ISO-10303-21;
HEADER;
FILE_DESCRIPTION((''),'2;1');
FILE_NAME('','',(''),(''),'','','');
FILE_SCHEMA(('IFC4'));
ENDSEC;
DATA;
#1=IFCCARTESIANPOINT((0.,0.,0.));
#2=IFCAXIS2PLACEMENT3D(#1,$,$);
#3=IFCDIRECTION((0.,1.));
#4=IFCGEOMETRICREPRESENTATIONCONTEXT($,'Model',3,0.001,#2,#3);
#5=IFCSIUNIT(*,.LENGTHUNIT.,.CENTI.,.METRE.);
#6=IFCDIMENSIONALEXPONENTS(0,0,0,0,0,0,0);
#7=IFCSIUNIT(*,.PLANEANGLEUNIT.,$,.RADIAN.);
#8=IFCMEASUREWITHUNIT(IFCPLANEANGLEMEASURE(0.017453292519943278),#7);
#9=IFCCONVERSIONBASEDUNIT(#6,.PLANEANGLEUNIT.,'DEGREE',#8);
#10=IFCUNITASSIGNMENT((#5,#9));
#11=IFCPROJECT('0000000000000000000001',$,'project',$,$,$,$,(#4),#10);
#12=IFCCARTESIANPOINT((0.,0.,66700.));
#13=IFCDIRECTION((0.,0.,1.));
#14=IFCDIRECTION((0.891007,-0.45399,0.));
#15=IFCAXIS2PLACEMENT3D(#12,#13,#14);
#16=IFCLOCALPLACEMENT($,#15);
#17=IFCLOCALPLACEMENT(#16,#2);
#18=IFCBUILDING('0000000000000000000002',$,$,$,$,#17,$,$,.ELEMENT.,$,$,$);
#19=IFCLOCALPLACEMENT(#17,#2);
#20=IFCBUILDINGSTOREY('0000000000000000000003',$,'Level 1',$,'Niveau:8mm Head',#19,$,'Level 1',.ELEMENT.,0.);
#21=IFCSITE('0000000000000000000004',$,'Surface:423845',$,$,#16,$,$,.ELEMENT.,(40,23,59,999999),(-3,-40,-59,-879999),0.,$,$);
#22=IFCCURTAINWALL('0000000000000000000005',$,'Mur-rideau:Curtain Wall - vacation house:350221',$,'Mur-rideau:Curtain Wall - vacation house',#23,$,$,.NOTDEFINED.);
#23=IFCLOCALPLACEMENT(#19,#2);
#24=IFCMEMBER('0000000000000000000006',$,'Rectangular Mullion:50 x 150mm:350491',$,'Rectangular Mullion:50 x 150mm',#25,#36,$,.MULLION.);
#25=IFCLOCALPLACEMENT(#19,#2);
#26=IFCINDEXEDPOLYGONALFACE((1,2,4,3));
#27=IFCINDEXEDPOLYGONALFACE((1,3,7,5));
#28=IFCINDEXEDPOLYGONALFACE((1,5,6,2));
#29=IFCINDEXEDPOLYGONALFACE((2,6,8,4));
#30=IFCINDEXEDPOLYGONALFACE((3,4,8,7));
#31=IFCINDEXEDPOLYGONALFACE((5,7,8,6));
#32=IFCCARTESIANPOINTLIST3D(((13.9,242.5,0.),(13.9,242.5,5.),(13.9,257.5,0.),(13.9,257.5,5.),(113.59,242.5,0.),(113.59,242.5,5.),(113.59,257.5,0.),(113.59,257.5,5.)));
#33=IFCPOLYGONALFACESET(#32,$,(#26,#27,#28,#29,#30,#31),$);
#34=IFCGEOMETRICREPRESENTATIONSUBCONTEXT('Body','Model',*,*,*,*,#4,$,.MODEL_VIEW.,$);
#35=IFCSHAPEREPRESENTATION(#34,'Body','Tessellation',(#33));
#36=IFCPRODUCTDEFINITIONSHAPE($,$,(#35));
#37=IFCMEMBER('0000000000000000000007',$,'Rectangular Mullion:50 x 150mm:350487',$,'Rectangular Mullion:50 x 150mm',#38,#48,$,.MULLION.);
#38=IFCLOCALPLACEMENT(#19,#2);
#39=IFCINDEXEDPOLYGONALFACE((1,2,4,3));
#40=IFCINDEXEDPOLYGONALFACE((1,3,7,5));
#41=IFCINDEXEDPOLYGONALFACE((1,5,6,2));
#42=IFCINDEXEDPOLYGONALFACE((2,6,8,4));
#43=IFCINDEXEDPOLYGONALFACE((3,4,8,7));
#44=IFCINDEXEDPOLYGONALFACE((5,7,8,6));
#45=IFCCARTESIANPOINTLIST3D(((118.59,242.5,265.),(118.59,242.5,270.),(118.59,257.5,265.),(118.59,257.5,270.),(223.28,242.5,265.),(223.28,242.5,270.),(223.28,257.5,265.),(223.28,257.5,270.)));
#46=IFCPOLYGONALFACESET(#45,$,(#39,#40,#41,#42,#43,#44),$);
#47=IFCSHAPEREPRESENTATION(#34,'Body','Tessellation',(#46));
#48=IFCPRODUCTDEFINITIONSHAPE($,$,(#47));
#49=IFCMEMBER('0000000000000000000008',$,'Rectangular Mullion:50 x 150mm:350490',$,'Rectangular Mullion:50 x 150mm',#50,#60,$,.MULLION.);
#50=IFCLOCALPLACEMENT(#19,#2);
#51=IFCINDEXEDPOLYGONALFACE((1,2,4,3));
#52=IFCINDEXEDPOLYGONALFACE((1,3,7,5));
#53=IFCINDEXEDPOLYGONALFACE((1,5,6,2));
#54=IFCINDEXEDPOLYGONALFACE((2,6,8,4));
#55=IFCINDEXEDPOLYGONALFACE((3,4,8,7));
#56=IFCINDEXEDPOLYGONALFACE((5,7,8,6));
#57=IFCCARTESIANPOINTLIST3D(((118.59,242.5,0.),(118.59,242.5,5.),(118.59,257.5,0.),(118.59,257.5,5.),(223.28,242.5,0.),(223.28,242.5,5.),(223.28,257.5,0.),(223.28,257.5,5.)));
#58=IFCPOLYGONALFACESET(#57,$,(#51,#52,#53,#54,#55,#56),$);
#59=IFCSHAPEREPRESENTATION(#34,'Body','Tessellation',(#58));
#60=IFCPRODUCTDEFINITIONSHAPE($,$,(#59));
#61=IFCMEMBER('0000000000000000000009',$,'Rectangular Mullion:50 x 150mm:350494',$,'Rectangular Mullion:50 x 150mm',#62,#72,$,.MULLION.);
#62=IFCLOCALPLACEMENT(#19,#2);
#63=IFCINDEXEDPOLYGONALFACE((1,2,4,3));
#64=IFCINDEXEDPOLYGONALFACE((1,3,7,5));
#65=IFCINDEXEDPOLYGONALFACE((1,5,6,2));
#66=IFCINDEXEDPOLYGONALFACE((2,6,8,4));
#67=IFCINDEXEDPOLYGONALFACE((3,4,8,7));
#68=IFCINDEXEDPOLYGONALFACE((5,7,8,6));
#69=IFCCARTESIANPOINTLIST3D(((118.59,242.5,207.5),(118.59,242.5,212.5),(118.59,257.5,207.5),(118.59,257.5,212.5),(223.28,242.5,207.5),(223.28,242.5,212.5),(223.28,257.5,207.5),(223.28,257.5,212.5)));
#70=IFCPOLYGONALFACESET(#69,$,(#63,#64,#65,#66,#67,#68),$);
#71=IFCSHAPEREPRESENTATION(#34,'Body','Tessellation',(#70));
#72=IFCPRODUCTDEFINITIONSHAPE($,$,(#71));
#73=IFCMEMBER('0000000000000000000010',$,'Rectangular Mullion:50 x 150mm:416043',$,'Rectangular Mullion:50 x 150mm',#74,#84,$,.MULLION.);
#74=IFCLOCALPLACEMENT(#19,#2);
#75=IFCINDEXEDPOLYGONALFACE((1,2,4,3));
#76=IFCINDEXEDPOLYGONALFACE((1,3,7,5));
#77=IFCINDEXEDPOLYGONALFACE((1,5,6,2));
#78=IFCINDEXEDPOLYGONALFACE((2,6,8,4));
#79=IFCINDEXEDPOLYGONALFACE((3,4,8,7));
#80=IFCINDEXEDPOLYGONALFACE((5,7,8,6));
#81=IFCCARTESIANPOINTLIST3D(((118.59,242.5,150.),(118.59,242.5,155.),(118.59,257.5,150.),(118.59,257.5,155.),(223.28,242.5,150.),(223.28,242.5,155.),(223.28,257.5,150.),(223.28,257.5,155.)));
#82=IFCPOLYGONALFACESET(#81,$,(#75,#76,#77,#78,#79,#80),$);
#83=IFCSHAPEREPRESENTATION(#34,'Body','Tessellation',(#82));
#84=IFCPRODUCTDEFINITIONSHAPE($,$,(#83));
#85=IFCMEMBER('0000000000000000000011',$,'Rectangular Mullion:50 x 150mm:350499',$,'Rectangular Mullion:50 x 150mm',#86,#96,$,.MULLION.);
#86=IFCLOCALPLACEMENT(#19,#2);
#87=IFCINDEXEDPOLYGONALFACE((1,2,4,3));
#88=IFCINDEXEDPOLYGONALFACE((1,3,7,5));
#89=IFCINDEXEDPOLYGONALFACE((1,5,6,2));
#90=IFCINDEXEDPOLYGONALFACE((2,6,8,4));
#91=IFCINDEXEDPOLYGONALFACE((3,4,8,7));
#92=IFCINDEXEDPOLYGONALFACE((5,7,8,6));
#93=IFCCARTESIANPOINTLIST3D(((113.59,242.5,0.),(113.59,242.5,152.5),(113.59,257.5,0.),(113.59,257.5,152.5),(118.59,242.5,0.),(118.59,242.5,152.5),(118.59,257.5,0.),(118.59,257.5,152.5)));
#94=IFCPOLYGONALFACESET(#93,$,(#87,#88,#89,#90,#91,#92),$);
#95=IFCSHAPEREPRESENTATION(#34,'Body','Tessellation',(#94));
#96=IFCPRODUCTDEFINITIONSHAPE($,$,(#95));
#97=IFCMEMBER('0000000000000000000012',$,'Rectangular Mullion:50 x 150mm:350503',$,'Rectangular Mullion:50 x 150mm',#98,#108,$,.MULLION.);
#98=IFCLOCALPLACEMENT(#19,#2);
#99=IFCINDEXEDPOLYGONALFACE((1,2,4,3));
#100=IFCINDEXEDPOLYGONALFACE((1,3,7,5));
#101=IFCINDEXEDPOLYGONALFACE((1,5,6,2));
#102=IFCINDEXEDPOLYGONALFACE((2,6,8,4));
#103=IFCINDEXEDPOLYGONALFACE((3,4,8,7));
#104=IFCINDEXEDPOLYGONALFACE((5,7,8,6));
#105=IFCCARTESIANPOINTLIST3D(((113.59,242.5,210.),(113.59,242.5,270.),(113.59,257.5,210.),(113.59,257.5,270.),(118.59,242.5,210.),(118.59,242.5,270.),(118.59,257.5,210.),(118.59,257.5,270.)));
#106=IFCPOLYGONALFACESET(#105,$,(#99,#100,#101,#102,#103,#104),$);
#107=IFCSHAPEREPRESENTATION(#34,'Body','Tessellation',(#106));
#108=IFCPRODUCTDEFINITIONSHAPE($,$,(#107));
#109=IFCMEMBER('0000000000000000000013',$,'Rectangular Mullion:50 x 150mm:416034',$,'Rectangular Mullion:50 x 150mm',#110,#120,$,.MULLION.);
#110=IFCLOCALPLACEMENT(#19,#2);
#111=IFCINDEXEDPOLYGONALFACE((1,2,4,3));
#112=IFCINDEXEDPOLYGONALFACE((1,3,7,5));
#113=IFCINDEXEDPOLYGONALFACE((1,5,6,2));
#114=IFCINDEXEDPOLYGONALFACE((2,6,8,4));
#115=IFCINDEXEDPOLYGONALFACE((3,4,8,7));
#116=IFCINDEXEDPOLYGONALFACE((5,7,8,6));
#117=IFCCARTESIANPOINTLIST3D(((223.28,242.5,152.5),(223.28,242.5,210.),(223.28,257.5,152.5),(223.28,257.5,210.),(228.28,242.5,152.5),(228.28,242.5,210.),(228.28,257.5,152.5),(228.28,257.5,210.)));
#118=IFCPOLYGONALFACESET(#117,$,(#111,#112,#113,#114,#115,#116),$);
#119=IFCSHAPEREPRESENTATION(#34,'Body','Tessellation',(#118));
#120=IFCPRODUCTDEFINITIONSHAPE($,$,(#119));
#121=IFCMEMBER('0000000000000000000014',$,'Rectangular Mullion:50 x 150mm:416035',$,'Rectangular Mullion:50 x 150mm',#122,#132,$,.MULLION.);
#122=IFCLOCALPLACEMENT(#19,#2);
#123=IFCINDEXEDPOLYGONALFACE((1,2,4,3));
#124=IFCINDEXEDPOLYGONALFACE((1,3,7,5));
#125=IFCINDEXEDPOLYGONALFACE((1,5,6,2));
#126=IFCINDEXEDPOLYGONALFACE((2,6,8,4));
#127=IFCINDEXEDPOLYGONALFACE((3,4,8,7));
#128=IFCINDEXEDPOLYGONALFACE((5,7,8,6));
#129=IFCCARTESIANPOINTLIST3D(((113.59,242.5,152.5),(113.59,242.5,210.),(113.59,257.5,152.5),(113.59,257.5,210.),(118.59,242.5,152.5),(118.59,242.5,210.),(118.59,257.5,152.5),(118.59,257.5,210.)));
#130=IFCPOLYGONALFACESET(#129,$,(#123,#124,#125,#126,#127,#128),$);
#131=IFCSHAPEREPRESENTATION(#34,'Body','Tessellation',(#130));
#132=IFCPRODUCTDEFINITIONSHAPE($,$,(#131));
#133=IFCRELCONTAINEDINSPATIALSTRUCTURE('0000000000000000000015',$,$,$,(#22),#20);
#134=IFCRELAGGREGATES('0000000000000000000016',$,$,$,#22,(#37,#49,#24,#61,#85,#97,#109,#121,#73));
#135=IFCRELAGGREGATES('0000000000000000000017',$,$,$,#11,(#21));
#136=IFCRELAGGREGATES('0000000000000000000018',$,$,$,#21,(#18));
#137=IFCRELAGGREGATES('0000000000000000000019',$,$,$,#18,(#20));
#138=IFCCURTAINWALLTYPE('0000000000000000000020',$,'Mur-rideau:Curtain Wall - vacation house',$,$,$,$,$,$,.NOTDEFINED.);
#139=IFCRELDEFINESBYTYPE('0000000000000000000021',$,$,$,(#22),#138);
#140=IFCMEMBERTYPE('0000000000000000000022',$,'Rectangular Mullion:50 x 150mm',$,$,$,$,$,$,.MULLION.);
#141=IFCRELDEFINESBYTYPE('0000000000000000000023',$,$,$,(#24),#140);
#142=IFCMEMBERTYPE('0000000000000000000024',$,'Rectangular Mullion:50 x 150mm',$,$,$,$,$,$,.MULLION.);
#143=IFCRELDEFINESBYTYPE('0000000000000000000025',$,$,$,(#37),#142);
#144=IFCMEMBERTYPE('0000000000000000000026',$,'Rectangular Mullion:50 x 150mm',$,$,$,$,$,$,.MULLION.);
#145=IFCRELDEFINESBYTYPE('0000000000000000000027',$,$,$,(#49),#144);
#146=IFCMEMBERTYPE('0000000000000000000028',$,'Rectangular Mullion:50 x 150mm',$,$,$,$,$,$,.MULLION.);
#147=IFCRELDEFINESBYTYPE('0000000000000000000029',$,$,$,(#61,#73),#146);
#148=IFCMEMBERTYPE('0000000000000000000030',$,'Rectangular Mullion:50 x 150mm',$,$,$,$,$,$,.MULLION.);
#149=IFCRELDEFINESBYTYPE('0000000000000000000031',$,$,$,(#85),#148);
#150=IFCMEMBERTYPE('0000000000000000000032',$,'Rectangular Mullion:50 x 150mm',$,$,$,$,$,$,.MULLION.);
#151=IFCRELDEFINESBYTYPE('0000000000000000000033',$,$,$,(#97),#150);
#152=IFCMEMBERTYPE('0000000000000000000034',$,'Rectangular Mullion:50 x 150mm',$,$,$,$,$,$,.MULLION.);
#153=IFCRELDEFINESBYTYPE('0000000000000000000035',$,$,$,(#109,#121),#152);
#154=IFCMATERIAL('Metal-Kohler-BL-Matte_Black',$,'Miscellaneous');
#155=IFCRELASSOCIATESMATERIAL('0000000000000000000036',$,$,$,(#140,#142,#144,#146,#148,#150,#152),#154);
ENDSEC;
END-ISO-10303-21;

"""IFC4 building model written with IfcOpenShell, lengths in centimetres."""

from ifc_helpers import new_model, entity, si_unit, converted_unit, direction, frame, origin, origin_2d_with_axis, place, context, subcontext, project, spatial, rectangle, extrude, source, transform, mapped, material, material_profile, profile_set, type_object, type_shapes, element, aggregate, save


model = new_model("IFC4")

# Units and contexts
model_context = context("Model", 3, precision=0.001, world=origin(), true_north=direction((0.0, 1.0)))
body_context = subcontext(model_context, "Body", "Model", "MODEL_VIEW")
ifc_project = project(units=[si_unit("LENGTHUNIT", "METRE", prefix="CENTI"), converted_unit("PLANEANGLEUNIT", "DEGREE", entity("IfcPlaneAngleMeasure", 0.017453292519943278), si_unit("PLANEANGLEUNIT", "RADIAN"), dimensions=[0, 0, 0, 0, 0, 0, 0])], contexts=[model_context])

# Site, building, storey
site_placement = place(None, frame((0.0, 0.0, 66700.0), z_axis=(0.0, 0.0, 1.0), x_axis=(0.891007, -0.45399, 0.0)))
site = spatial("IfcSite", under=ifc_project, at=site_placement, Name="Surface:423845", CompositionType="ELEMENT", RefLatitude=(40, 23, 59, 999999), RefLongitude=(-3, -40, -59, -879999), RefElevation=0.0)
building_placement = place(site_placement, origin())
building = spatial("IfcBuilding", under=site, at=building_placement, CompositionType="ELEMENT")
storey_placement = place(building_placement, origin())
storey = spatial("IfcBuildingStorey", under=building, at=storey_placement, Name="Level 1", ObjectType="Niveau:8mm Head", LongName="Level 1", CompositionType="ELEMENT", Elevation=0.0)

# Curtain wall, members
curtain_wall_type = type_object("IfcCurtainWallType", Name="Mur-rideau:Curtain Wall - vacation house", PredefinedType="NOTDEFINED")
curtain_wall_placement = place(storey_placement, origin())
curtain_wall = element("IfcCurtainWall", 1, at=curtain_wall_placement, inside=storey, type_object=curtain_wall_type, Name="Mur-rideau:Curtain Wall - vacation house:350221", ObjectType="Mur-rideau:Curtain Wall - vacation house", PredefinedType="NOTDEFINED")
ifc_material_1 = material(Name="Metal-Kohler-BL-Matte_Black", Category="Miscellaneous")
ifc_material_profile = material_profile(ifc_material_1, rectangle(XDim=5.0, YDim=15.0, at=origin_2d_with_axis()), Name="50 x 150mm")
ifc_profile_set = profile_set([ifc_material_profile], Name="50 x 150mm")
member_type_1 = type_object("IfcMemberType", Name="Rectangular Mullion:50 x 150mm", PredefinedType="MULLION", material=ifc_profile_set)
shared_shape_1 = source(origin(), body_context, "Body", "SweptSolid", [
    extrude(rectangle(XDim=5.0, YDim=15.0, at=origin_2d_with_axis()), frame((-2.5, 0.0, -99.69), z_axis=(0.0, 0.0, 1.0), x_axis=(-1.0, 0.0, 0.0)), (0.0, 0.0, 1.0), 99.69),
])
type_shapes(member_type_1, [shared_shape_1])
member_1_placement = place(curtain_wall_placement, frame((113.59, 250.0, 0.0), z_axis=(1.0, 0.0, 0.0), x_axis=(0.0, 0.0, -1.0)))
member_1 = element("IfcMember", 2, at=member_1_placement, type_object=member_type_1, Name="Rectangular Mullion:50 x 150mm:350491", ObjectType="Rectangular Mullion:50 x 150mm", PredefinedType="MULLION", context=body_context, shape_type="MappedRepresentation", body=[
    mapped(shared_shape_1, transform((0.0, 0.0, 0.0), scale=1.0)),
])
member_type_2 = type_object("IfcMemberType", Name="Rectangular Mullion:50 x 150mm", PredefinedType="MULLION", material=ifc_profile_set)
shared_shape_2 = source(origin(), body_context, "Body", "SweptSolid", [
    extrude(rectangle(XDim=5.0, YDim=15.0, at=origin_2d_with_axis()), frame((-2.5, 0.0, -104.69), z_axis=(0.0, 0.0, 1.0), x_axis=(-1.0, 0.0, 0.0)), (0.0, 0.0, 1.0), 104.69),
])
type_shapes(member_type_2, [shared_shape_2])
member_2_placement = place(curtain_wall_placement, frame((118.59, 250.0, 270.0), z_axis=(-1.0, 0.0, 0.0), x_axis=(0.0, 0.0, 1.0)))
member_2 = element("IfcMember", 3, at=member_2_placement, type_object=member_type_2, Name="Rectangular Mullion:50 x 150mm:350487", ObjectType="Rectangular Mullion:50 x 150mm", PredefinedType="MULLION", context=body_context, shape_type="MappedRepresentation", body=[
    mapped(shared_shape_2, transform((0.0, 0.0, 0.0), scale=1.0)),
])
member_type_3 = type_object("IfcMemberType", Name="Rectangular Mullion:50 x 150mm", PredefinedType="MULLION", material=ifc_profile_set)
shared_shape_3 = source(origin(), body_context, "Body", "SweptSolid", [
    extrude(rectangle(XDim=5.0, YDim=15.0, at=origin_2d_with_axis()), frame((-2.5, 0.0, -104.69), z_axis=(0.0, 0.0, 1.0), x_axis=(-1.0, 0.0, 0.0)), (0.0, 0.0, 1.0), 104.69),
])
type_shapes(member_type_3, [shared_shape_3])
member_3_placement = place(curtain_wall_placement, frame((223.28, 250.0, 0.0), z_axis=(1.0, 0.0, 0.0), x_axis=(0.0, 0.0, -1.0)))
member_3 = element("IfcMember", 4, at=member_3_placement, type_object=member_type_3, Name="Rectangular Mullion:50 x 150mm:350490", ObjectType="Rectangular Mullion:50 x 150mm", PredefinedType="MULLION", context=body_context, shape_type="MappedRepresentation", body=[
    mapped(shared_shape_3, transform((0.0, 0.0, 0.0), scale=1.0)),
])
member_type_4 = type_object("IfcMemberType", Name="Rectangular Mullion:50 x 150mm", PredefinedType="MULLION", material=ifc_profile_set)
shared_shape_4 = source(origin(), body_context, "Body", "SweptSolid", [
    extrude(rectangle(XDim=5.0, YDim=15.0, at=origin_2d_with_axis()), frame((0.0, 0.0, -104.69), z_axis=(0.0, 0.0, 1.0), x_axis=(-1.0, 0.0, 0.0)), (0.0, 0.0, 1.0), 104.69),
])
type_shapes(member_type_4, [shared_shape_4])
member_4_placement = place(curtain_wall_placement, frame((118.59, 250.0, 210.0), z_axis=(-1.0, 0.0, 0.0), x_axis=(0.0, 0.0, 1.0)))
member_4 = element("IfcMember", 5, at=member_4_placement, type_object=member_type_4, Name="Rectangular Mullion:50 x 150mm:350494", ObjectType="Rectangular Mullion:50 x 150mm", PredefinedType="MULLION", context=body_context, shape_type="MappedRepresentation", body=[
    mapped(shared_shape_4, transform((0.0, 0.0, 0.0), scale=1.0)),
])
member_5_placement = place(curtain_wall_placement, frame((118.59, 250.0, 152.5), z_axis=(-1.0, 0.0, 0.0), x_axis=(0.0, 0.0, 1.0)))
member_5 = element("IfcMember", 6, at=member_5_placement, type_object=member_type_4, Name="Rectangular Mullion:50 x 150mm:416043", ObjectType="Rectangular Mullion:50 x 150mm", PredefinedType="MULLION", context=body_context, shape_type="MappedRepresentation", body=[
    mapped(shared_shape_4, transform((0.0, 0.0, 0.0), scale=1.0)),
])
member_type_5 = type_object("IfcMemberType", Name="Rectangular Mullion:50 x 150mm", PredefinedType="MULLION", material=ifc_profile_set)
shared_shape_5 = source(origin(), body_context, "Body", "SweptSolid", [
    extrude(rectangle(XDim=5.0, YDim=15.0, at=origin_2d_with_axis()), frame((0.0, 0.0, -152.5), z_axis=(0.0, 0.0, 1.0), x_axis=(-1.0, 0.0, 0.0)), (0.0, 0.0, 1.0), 152.5),
])
type_shapes(member_type_5, [shared_shape_5])
member_6_placement = place(curtain_wall_placement, frame((116.09, 250.0, 0.0), z_axis=(0.0, 0.0, -1.0), x_axis=(-1.0, 0.0, 0.0)))
member_6 = element("IfcMember", 7, at=member_6_placement, type_object=member_type_5, Name="Rectangular Mullion:50 x 150mm:350499", ObjectType="Rectangular Mullion:50 x 150mm", PredefinedType="MULLION", context=body_context, shape_type="MappedRepresentation", body=[
    mapped(shared_shape_5, transform((0.0, 0.0, 0.0), scale=1.0)),
])
member_type_6 = type_object("IfcMemberType", Name="Rectangular Mullion:50 x 150mm", PredefinedType="MULLION", material=ifc_profile_set)
shared_shape_6 = source(origin(), body_context, "Body", "SweptSolid", [
    extrude(rectangle(XDim=5.0, YDim=15.0, at=origin_2d_with_axis()), frame((0.0, 0.0, -60.0), z_axis=(0.0, 0.0, 1.0), x_axis=(-1.0, 0.0, 0.0)), (0.0, 0.0, 1.0), 60.0),
])
type_shapes(member_type_6, [shared_shape_6])
member_7_placement = place(curtain_wall_placement, frame((116.09, 250.0, 210.0), z_axis=(0.0, 0.0, -1.0), x_axis=(-1.0, 0.0, 0.0)))
member_7 = element("IfcMember", 8, at=member_7_placement, type_object=member_type_6, Name="Rectangular Mullion:50 x 150mm:350503", ObjectType="Rectangular Mullion:50 x 150mm", PredefinedType="MULLION", context=body_context, shape_type="MappedRepresentation", body=[
    mapped(shared_shape_6, transform((0.0, 0.0, 0.0), scale=1.0)),
])
member_type_7 = type_object("IfcMemberType", Name="Rectangular Mullion:50 x 150mm", PredefinedType="MULLION", material=ifc_profile_set)
shared_shape_7 = source(origin(), body_context, "Body", "SweptSolid", [
    extrude(rectangle(XDim=5.0, YDim=15.0, at=origin_2d_with_axis()), frame((0.0, 0.0, -57.5), z_axis=(0.0, 0.0, 1.0), x_axis=(-1.0, 0.0, 0.0)), (0.0, 0.0, 1.0), 57.5),
])
type_shapes(member_type_7, [shared_shape_7])
member_8_placement = place(curtain_wall_placement, frame((225.78, 250.0, 152.5), z_axis=(0.0, 0.0, -1.0), x_axis=(-1.0, 0.0, 0.0)))
member_8 = element("IfcMember", 9, at=member_8_placement, type_object=member_type_7, Name="Rectangular Mullion:50 x 150mm:416034", ObjectType="Rectangular Mullion:50 x 150mm", PredefinedType="MULLION", context=body_context, shape_type="MappedRepresentation", body=[
    mapped(shared_shape_7, transform((0.0, 0.0, 0.0), scale=1.0)),
])
member_9_placement = place(curtain_wall_placement, frame((116.09, 250.0, 152.5), z_axis=(0.0, 0.0, -1.0), x_axis=(-1.0, 0.0, 0.0)))
member_9 = element("IfcMember", 10, at=member_9_placement, type_object=member_type_7, Name="Rectangular Mullion:50 x 150mm:416035", ObjectType="Rectangular Mullion:50 x 150mm", PredefinedType="MULLION", context=body_context, shape_type="MappedRepresentation", body=[
    mapped(shared_shape_7, transform((0.0, 0.0, 0.0), scale=1.0)),
])
aggregate(curtain_wall, [member_2, member_3, member_1, member_4, member_6, member_7, member_8, member_9, member_5])

save(model, "model.ifc")
